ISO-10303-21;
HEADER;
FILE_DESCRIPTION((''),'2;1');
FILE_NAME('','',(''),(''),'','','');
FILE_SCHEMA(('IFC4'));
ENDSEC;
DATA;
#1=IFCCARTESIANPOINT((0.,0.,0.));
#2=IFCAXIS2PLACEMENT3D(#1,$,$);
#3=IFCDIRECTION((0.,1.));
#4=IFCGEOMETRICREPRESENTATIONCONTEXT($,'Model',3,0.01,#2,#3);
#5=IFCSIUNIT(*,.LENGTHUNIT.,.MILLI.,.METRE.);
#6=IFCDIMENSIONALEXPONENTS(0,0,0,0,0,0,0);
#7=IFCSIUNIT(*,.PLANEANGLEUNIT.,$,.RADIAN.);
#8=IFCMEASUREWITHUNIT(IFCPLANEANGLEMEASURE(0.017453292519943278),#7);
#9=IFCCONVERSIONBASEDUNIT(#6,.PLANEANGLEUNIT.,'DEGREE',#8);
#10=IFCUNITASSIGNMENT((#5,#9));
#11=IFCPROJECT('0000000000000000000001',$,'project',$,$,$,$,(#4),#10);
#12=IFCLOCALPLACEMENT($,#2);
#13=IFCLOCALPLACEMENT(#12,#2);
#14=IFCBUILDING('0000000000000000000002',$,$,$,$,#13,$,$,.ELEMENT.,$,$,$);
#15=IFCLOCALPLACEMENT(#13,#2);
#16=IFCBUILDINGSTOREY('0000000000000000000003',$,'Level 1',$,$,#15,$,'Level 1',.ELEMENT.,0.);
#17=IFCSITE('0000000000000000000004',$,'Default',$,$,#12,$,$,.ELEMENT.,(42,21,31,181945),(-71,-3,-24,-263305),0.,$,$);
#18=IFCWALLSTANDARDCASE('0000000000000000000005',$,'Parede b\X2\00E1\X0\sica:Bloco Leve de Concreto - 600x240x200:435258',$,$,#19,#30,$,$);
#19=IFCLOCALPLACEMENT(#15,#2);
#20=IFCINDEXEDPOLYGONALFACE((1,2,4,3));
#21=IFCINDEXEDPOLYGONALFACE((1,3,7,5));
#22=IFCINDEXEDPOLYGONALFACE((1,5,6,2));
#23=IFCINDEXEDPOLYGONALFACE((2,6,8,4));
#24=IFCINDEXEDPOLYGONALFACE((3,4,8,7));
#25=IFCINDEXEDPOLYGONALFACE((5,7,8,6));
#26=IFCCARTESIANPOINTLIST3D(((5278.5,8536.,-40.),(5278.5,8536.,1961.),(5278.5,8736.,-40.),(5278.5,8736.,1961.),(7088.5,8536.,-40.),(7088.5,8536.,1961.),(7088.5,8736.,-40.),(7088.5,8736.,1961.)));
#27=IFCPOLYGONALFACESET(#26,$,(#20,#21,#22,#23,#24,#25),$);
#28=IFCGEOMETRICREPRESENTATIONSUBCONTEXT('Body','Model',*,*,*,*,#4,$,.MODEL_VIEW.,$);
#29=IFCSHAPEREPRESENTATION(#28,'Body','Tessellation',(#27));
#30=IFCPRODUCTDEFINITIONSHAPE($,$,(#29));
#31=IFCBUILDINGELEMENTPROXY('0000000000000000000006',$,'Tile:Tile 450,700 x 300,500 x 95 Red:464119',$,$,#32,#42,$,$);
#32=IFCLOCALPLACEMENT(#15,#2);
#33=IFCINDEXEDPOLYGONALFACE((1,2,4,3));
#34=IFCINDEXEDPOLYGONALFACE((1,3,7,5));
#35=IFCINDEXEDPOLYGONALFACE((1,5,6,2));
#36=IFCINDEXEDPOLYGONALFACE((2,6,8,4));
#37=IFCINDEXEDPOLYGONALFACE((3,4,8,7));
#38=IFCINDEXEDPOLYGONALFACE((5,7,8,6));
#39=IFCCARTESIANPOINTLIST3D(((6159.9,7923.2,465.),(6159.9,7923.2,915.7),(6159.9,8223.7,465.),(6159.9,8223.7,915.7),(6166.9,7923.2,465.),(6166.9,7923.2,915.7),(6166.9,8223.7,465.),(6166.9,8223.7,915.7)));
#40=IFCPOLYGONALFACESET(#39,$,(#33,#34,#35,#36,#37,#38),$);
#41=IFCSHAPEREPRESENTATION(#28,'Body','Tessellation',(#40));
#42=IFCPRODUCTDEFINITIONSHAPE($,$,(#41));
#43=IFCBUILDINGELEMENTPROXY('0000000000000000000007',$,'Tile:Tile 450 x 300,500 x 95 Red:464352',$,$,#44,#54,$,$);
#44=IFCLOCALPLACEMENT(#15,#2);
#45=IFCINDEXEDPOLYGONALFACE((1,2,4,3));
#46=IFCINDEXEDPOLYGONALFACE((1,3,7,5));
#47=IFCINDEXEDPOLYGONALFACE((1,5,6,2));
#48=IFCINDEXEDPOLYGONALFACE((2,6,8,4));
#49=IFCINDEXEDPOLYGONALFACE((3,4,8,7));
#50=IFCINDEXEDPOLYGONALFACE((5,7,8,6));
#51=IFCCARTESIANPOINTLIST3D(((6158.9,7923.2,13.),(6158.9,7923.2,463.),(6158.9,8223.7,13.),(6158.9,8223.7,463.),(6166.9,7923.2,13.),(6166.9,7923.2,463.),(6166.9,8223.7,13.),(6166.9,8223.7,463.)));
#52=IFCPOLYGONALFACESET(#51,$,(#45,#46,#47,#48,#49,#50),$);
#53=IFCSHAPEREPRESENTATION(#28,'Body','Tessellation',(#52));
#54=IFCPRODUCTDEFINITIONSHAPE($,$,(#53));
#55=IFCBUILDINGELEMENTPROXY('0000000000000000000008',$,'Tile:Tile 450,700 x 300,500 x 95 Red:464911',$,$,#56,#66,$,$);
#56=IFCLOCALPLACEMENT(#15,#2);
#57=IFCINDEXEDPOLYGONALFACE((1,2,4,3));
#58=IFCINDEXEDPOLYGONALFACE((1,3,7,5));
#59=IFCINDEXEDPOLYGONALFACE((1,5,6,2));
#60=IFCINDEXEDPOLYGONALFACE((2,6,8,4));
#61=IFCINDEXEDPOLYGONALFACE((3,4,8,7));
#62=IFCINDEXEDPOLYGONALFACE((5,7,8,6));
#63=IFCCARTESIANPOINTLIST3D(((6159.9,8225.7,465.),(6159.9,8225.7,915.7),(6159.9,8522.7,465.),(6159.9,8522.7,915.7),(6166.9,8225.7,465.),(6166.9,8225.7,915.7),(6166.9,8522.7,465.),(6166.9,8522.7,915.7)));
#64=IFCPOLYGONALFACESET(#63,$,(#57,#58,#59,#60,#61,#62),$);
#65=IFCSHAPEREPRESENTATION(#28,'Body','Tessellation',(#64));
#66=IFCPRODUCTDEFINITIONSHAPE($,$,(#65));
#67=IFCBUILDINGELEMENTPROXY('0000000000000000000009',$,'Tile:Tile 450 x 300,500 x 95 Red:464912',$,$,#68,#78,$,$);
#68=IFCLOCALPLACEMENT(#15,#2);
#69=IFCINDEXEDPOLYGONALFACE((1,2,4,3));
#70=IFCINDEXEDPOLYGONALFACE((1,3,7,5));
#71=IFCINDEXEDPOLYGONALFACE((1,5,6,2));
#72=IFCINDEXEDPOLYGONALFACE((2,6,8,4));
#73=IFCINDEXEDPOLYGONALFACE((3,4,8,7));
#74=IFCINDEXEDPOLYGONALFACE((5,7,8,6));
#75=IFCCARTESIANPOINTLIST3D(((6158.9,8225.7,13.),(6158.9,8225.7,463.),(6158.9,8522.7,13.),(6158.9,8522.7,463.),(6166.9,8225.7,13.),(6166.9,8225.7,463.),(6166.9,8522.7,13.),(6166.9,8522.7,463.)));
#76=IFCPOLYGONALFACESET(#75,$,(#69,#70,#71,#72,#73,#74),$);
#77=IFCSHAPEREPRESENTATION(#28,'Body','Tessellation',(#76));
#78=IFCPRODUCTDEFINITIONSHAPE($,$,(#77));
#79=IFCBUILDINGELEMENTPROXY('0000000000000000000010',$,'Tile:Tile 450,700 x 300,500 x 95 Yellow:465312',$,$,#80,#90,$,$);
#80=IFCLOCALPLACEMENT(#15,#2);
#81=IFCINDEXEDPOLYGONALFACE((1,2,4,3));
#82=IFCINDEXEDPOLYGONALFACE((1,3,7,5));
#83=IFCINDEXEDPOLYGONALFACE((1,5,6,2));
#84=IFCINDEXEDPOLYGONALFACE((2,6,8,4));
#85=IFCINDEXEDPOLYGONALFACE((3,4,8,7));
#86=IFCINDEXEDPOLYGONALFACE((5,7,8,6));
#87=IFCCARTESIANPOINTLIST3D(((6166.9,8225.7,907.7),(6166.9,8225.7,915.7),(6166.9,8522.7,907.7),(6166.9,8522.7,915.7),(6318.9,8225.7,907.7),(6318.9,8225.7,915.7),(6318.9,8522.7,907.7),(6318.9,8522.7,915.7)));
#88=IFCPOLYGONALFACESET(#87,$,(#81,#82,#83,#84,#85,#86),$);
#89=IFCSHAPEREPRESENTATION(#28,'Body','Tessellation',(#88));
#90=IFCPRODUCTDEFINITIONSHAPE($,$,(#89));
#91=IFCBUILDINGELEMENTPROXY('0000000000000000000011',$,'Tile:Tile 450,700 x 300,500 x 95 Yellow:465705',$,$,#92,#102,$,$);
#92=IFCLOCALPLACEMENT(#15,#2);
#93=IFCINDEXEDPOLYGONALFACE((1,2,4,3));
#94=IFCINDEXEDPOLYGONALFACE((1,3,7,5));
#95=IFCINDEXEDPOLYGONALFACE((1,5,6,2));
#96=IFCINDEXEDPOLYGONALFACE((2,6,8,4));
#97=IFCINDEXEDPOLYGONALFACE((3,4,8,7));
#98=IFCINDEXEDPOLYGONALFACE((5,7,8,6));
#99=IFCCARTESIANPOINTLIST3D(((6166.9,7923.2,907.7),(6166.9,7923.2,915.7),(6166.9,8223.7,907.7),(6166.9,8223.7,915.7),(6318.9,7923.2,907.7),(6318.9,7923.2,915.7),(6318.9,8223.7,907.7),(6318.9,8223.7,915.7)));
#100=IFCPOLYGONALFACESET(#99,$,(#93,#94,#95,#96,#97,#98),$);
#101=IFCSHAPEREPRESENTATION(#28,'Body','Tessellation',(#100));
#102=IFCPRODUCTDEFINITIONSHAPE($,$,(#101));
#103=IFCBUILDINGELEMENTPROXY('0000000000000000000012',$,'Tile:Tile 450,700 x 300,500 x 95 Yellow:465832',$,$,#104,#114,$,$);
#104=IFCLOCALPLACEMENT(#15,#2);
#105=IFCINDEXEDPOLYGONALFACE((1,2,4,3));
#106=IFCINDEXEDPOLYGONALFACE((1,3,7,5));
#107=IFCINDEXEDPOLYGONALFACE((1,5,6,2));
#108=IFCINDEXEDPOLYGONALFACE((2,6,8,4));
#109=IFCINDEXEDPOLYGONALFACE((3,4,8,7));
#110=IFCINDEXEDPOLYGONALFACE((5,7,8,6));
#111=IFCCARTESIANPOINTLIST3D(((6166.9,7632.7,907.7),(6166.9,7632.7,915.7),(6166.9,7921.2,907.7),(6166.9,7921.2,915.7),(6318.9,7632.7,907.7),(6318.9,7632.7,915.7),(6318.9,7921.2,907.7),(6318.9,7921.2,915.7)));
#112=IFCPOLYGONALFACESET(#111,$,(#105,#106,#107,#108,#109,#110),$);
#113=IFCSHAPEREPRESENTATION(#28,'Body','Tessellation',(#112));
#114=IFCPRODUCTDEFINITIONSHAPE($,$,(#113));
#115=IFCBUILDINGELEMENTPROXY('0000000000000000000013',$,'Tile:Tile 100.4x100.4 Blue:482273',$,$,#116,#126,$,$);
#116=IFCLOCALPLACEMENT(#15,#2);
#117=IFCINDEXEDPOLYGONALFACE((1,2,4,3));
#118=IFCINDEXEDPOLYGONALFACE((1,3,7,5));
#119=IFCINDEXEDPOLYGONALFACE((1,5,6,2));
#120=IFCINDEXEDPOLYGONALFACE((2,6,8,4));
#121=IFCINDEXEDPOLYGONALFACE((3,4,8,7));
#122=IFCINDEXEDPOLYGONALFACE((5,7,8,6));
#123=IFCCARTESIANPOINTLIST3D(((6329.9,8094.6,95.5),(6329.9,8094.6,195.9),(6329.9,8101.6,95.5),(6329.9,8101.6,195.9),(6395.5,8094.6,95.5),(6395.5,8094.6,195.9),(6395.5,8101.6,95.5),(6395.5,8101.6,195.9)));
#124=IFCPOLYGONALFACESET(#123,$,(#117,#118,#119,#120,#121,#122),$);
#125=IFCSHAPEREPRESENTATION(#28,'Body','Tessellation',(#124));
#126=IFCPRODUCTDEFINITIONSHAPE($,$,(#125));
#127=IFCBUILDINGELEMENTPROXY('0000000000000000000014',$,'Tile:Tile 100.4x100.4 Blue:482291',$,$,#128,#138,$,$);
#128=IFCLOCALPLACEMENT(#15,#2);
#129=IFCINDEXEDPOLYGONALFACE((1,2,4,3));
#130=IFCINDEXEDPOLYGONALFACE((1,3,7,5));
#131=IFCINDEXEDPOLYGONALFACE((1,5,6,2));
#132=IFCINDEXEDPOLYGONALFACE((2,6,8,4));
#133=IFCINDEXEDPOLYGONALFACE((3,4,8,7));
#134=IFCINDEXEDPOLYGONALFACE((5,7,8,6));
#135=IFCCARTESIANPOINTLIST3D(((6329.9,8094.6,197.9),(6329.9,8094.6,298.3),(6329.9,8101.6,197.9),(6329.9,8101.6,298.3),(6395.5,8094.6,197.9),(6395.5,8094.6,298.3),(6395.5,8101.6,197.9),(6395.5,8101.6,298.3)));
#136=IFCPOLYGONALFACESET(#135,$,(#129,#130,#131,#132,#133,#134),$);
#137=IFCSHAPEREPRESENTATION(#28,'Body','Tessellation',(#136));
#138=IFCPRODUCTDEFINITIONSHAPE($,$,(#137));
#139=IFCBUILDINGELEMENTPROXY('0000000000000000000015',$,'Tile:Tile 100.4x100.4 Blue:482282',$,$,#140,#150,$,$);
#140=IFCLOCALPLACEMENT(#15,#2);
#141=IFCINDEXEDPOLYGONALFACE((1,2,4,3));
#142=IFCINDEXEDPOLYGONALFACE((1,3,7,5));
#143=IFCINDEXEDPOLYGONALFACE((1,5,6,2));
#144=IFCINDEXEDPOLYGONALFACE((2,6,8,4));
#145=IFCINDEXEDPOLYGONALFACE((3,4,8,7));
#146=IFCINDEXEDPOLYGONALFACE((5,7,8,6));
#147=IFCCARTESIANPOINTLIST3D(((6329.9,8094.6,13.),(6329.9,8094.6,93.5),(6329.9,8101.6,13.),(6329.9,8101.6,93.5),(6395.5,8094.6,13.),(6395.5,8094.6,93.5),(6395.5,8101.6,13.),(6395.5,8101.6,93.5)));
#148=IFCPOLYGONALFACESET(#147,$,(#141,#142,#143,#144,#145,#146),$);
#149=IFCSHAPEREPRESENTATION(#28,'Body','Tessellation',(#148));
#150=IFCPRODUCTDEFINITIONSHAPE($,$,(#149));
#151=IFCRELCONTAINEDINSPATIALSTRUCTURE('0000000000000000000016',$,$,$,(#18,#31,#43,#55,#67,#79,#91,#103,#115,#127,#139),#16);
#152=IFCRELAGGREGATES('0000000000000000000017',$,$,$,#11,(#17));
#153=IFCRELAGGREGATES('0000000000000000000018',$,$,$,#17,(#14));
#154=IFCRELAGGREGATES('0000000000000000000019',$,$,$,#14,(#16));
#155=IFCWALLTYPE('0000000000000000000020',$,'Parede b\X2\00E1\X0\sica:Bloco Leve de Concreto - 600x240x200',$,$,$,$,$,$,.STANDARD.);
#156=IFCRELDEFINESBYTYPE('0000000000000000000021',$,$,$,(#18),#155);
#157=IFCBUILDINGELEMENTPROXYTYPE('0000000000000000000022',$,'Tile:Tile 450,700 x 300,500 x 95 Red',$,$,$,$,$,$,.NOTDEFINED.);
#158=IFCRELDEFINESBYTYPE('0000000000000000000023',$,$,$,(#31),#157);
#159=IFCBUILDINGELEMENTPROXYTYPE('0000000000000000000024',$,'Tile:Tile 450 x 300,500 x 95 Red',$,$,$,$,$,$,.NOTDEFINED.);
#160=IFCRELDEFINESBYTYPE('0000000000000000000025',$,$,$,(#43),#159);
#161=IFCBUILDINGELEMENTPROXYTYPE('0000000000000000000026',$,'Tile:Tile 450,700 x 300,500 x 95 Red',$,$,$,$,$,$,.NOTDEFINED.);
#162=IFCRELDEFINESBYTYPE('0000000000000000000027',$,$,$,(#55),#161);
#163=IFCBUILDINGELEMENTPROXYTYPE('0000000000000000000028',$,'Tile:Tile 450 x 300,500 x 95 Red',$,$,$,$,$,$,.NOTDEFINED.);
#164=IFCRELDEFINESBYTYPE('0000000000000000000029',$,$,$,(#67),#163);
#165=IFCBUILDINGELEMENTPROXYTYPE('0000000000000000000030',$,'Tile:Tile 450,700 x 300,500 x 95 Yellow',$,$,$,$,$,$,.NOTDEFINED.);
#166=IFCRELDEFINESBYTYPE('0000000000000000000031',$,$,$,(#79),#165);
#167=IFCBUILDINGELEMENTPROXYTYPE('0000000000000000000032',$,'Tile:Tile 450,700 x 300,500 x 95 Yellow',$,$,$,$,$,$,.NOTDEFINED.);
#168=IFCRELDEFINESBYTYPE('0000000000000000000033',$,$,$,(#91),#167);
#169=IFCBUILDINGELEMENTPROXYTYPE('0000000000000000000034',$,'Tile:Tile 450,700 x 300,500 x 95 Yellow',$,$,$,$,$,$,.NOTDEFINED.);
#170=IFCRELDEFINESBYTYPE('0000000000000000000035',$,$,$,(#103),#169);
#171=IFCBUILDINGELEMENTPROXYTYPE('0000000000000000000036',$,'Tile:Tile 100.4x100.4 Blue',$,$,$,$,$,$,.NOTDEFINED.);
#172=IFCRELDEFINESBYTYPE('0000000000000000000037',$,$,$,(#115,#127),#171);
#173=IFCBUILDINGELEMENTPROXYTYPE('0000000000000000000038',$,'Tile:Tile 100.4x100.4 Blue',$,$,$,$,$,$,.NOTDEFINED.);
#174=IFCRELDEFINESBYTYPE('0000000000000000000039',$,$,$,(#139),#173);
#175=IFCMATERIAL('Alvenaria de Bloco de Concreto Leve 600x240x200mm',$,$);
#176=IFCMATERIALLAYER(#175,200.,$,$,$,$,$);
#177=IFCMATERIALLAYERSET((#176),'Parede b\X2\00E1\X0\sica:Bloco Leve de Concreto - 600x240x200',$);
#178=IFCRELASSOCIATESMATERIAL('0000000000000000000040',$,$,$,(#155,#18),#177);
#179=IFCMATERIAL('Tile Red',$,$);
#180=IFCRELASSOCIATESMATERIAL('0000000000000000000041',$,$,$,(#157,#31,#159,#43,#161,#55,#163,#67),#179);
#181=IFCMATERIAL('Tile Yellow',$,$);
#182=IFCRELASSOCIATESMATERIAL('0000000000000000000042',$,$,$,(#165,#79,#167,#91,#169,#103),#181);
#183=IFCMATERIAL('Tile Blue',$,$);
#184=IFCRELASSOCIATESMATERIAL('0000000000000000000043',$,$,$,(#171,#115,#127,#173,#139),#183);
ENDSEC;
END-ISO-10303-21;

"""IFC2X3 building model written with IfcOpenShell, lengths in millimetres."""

from ifc_helpers import new_model, entity, si_unit, converted_unit, direction, frame, frame_2d, origin, origin_2d_with_axis, place, context, subcontext, project, spatial, rectangle, extrude, source, transform, mapped, material, layer, layer_set, layer_usage, type_object, type_shapes, element, save


model = new_model("IFC2X3")

# Units and contexts
model_context = context("Model", 3, precision=0.01, world=origin(), true_north=direction((0.0, 1.0)))
body_context = subcontext(model_context, "Body", "Model", "MODEL_VIEW")
ifc_project = project(units=[si_unit("LENGTHUNIT", "METRE", prefix="MILLI"), converted_unit("PLANEANGLEUNIT", "DEGREE", entity("IfcPlaneAngleMeasure", 0.017453292519943278), si_unit("PLANEANGLEUNIT", "RADIAN"), dimensions=[0, 0, 0, 0, 0, 0, 0])], contexts=[model_context])

# Site, building, storey
site_placement = place(None, origin())
site = spatial("IfcSite", under=ifc_project, at=site_placement, Name="Default", CompositionType="ELEMENT", RefLatitude=(42, 21, 31, 181945), RefLongitude=(-71, -3, -24, -263305), RefElevation=0.0)
building_placement = place(site_placement, origin())
building = spatial("IfcBuilding", under=site, at=building_placement, CompositionType="ELEMENT")
storey_placement = place(building_placement, origin())
storey = spatial("IfcBuildingStorey", under=building, at=storey_placement, Name="Level 1", LongName="Level 1", CompositionType="ELEMENT", Elevation=0.0)

# Wall
ifc_material_1 = material(Name="Alvenaria de Bloco de Concreto Leve 600x240x200mm")
ifc_layer = layer(ifc_material_1, 200.0)
ifc_layer_set = layer_set([ifc_layer], Name="Parede básica:Bloco Leve de Concreto - 600x240x200")
ifc_layer_usage = layer_usage(ifc_layer_set, "AXIS2", "NEGATIVE", 100.0)
wall_type = type_object("IfcWallType", Name="Parede básica:Bloco Leve de Concreto - 600x240x200", PredefinedType="STANDARD", material=ifc_layer_set)
wall_placement = place(storey_placement, frame((5278.5, 8636.0, -40.0)))
element("IfcWallStandardCase", 1, at=wall_placement, inside=storey, type_object=wall_type, material=ifc_layer_usage, Name="Parede básica:Bloco Leve de Concreto - 600x240x200:435258", context=body_context, shape_type="SweptSolid", body=[
    extrude(rectangle(XDim=1810.0, YDim=200.0, at=frame_2d((905.0, 0.0), x_axis=(-1.0, 0.0))), origin(), (0.0, 0.0, 1.0), 2001.0),
])

# Building element proxies
ifc_material_2 = material(Name="Tile Red")
building_element_proxy_type_1 = type_object("IfcBuildingElementProxyType", Name="Tile:Tile 450,700 x 300,500 x 95 Red", PredefinedType="NOTDEFINED", material=ifc_material_2)
shared_shape_1 = source(origin(), body_context, "Body", "SweptSolid", [
    extrude(rectangle(XDim=300.5, YDim=450.7, at=frame_2d((0.0, 0.0), x_axis=(1.0, 0.0))), frame((-150.2, 225.4, 0.0)), (0.0, 0.0, 1.0), 7.0),
])
type_shapes(building_element_proxy_type_1, [shared_shape_1])
proxy_1_placement = place(storey_placement, frame((6166.9, 7923.2, 465.0), z_axis=(-1.0, 0.0, 0.0), x_axis=(0.0, -1.0, 0.0)))
element("IfcBuildingElementProxy", 2, at=proxy_1_placement, inside=storey, type_object=building_element_proxy_type_1, material=ifc_material_2, Name="Tile:Tile 450,700 x 300,500 x 95 Red:464119", context=body_context, shape_type="MappedRepresentation", body=[
    mapped(shared_shape_1, transform((0.0, 0.0, 0.0), scale=1.0)),
])
building_element_proxy_type_2 = type_object("IfcBuildingElementProxyType", Name="Tile:Tile 450 x 300,500 x 95 Red", PredefinedType="NOTDEFINED", material=ifc_material_2)
shared_shape_2 = source(origin(), body_context, "Body", "SweptSolid", [
    extrude(rectangle(XDim=300.5, YDim=450.0, at=frame_2d((0.0, 0.0), x_axis=(1.0, 0.0))), frame((-150.2, 225.0, 0.0)), (0.0, 0.0, 1.0), 8.0),
])
type_shapes(building_element_proxy_type_2, [shared_shape_2])
proxy_2_placement = place(storey_placement, frame((6166.9, 7923.2, 13.0), z_axis=(-1.0, 0.0, 0.0), x_axis=(0.0, -1.0, 0.0)))
element("IfcBuildingElementProxy", 3, at=proxy_2_placement, inside=storey, type_object=building_element_proxy_type_2, material=ifc_material_2, Name="Tile:Tile 450 x 300,500 x 95 Red:464352", context=body_context, shape_type="MappedRepresentation", body=[
    mapped(shared_shape_2, transform((0.0, 0.0, 0.0), scale=1.0)),
])
building_element_proxy_type_3 = type_object("IfcBuildingElementProxyType", Name="Tile:Tile 450,700 x 300,500 x 95 Red", PredefinedType="NOTDEFINED", material=ifc_material_2)
shared_shape_3 = source(origin(), body_context, "Body", "SweptSolid", [
    extrude(rectangle(XDim=450.7, YDim=297.0, at=origin_2d_with_axis()), frame((-148.5, 225.4, 0.0), z_axis=(0.0, 0.0, 1.0), x_axis=(0.0, 1.0, 0.0)), (0.0, 0.0, 1.0), 7.0),
])
type_shapes(building_element_proxy_type_3, [shared_shape_3])
proxy_3_placement = place(storey_placement, frame((6166.9, 8225.7, 465.0), z_axis=(-1.0, 0.0, 0.0), x_axis=(0.0, -1.0, 0.0)))
element("IfcBuildingElementProxy", 4, at=proxy_3_placement, inside=storey, type_object=building_element_proxy_type_3, material=ifc_material_2, Name="Tile:Tile 450,700 x 300,500 x 95 Red:464911", context=body_context, shape_type="MappedRepresentation", body=[
    mapped(shared_shape_3, transform((0.0, 0.0, 0.0), scale=1.0)),
])
building_element_proxy_type_4 = type_object("IfcBuildingElementProxyType", Name="Tile:Tile 450 x 300,500 x 95 Red", PredefinedType="NOTDEFINED", material=ifc_material_2)
shared_shape_4 = source(origin(), body_context, "Body", "SweptSolid", [
    extrude(rectangle(XDim=450.0, YDim=297.0, at=origin_2d_with_axis()), frame((-148.5, 225.0, 0.0), z_axis=(0.0, 0.0, 1.0), x_axis=(0.0, 1.0, 0.0)), (0.0, 0.0, 1.0), 8.0),
])
type_shapes(building_element_proxy_type_4, [shared_shape_4])
proxy_4_placement = place(storey_placement, frame((6166.9, 8225.7, 13.0), z_axis=(-1.0, 0.0, 0.0), x_axis=(0.0, -1.0, 0.0)))
element("IfcBuildingElementProxy", 5, at=proxy_4_placement, inside=storey, type_object=building_element_proxy_type_4, material=ifc_material_2, Name="Tile:Tile 450 x 300,500 x 95 Red:464912", context=body_context, shape_type="MappedRepresentation", body=[
    mapped(shared_shape_4, transform((0.0, 0.0, 0.0), scale=1.0)),
])
ifc_material_3 = material(Name="Tile Yellow")
building_element_proxy_type_5 = type_object("IfcBuildingElementProxyType", Name="Tile:Tile 450,700 x 300,500 x 95 Yellow", PredefinedType="NOTDEFINED", material=ifc_material_3)
shared_shape_5 = source(origin(), body_context, "Body", "SweptSolid", [
    extrude(rectangle(XDim=152.0, YDim=297.0, at=origin_2d_with_axis()), frame((-76.0, -148.5, 0.0), z_axis=(0.0, 0.0, 1.0), x_axis=(-1.0, 0.0, 0.0)), (0.0, 0.0, 1.0), 8.0),
])
type_shapes(building_element_proxy_type_5, [shared_shape_5])
proxy_5_placement = place(storey_placement, frame((6318.9, 8522.7, 907.7)))
element("IfcBuildingElementProxy", 6, at=proxy_5_placement, inside=storey, type_object=building_element_proxy_type_5, material=ifc_material_3, Name="Tile:Tile 450,700 x 300,500 x 95 Yellow:465312", context=body_context, shape_type="MappedRepresentation", body=[
    mapped(shared_shape_5, transform((0.0, 0.0, 0.0), scale=1.0)),
])
building_element_proxy_type_6 = type_object("IfcBuildingElementProxyType", Name="Tile:Tile 450,700 x 300,500 x 95 Yellow", PredefinedType="NOTDEFINED", material=ifc_material_3)
shared_shape_6 = source(origin(), body_context, "Body", "SweptSolid", [
    extrude(rectangle(XDim=152.0, YDim=300.5, at=origin_2d_with_axis()), frame((-76.0, -150.3, 0.0), z_axis=(0.0, 0.0, 1.0), x_axis=(-1.0, 0.0, 0.0)), (0.0, 0.0, 1.0), 8.0),
])
type_shapes(building_element_proxy_type_6, [shared_shape_6])
proxy_6_placement = place(storey_placement, frame((6318.9, 8223.7, 907.7)))
element("IfcBuildingElementProxy", 7, at=proxy_6_placement, inside=storey, type_object=building_element_proxy_type_6, material=ifc_material_3, Name="Tile:Tile 450,700 x 300,500 x 95 Yellow:465705", context=body_context, shape_type="MappedRepresentation", body=[
    mapped(shared_shape_6, transform((0.0, 0.0, 0.0), scale=1.0)),
])
building_element_proxy_type_7 = type_object("IfcBuildingElementProxyType", Name="Tile:Tile 450,700 x 300,500 x 95 Yellow", PredefinedType="NOTDEFINED", material=ifc_material_3)
shared_shape_7 = source(origin(), body_context, "Body", "SweptSolid", [
    extrude(rectangle(XDim=152.0, YDim=288.5, at=origin_2d_with_axis()), frame((-76.0, -144.3, 0.0), z_axis=(0.0, 0.0, 1.0), x_axis=(-1.0, 0.0, 0.0)), (0.0, 0.0, 1.0), 8.0),
])
type_shapes(building_element_proxy_type_7, [shared_shape_7])
proxy_7_placement = place(storey_placement, frame((6318.9, 7921.2, 907.7)))
element("IfcBuildingElementProxy", 8, at=proxy_7_placement, inside=storey, type_object=building_element_proxy_type_7, material=ifc_material_3, Name="Tile:Tile 450,700 x 300,500 x 95 Yellow:465832", context=body_context, shape_type="MappedRepresentation", body=[
    mapped(shared_shape_7, transform((0.0, 0.0, 0.0), scale=1.0)),
])
ifc_material_4 = material(Name="Tile Blue")
building_element_proxy_type_8 = type_object("IfcBuildingElementProxyType", Name="Tile:Tile 100.4x100.4 Blue", PredefinedType="NOTDEFINED", material=ifc_material_4)
shared_shape_8 = source(origin(), body_context, "Body", "SweptSolid", [
    extrude(rectangle(XDim=65.6, YDim=100.4, at=frame_2d((0.0, 0.0), x_axis=(1.0, 0.0))), frame((-32.8, -50.2, 0.0), z_axis=(0.0, 0.0, 1.0), x_axis=(-1.0, 0.0, 0.0)), (0.0, 0.0, 1.0), 7.0),
])
type_shapes(building_element_proxy_type_8, [shared_shape_8])
for number, where, z_axis, x_axis, name in (
    (9, (6329.9, 8101.6, 95.5), (0.0, -1.0, 0.0), (-1.0, 0.0, 0.0), "Tile:Tile 100.4x100.4 Blue:482273"),
    (10, (6329.9, 8101.6, 197.9), (0.0, -1.0, 0.0), (-1.0, 0.0, 0.0), "Tile:Tile 100.4x100.4 Blue:482291"),
):
    element("IfcBuildingElementProxy", number, at=place(storey_placement, frame(where, z_axis=z_axis, x_axis=x_axis)), inside=storey, type_object=building_element_proxy_type_8, material=ifc_material_4, Name=name, context=body_context, shape_type="MappedRepresentation", body=[
        mapped(shared_shape_8, transform((0.0, 0.0, 0.0), scale=1.0)),
    ])
building_element_proxy_type_9 = type_object("IfcBuildingElementProxyType", Name="Tile:Tile 100.4x100.4 Blue", PredefinedType="NOTDEFINED", material=ifc_material_4)
shared_shape_9 = source(origin(), body_context, "Body", "SweptSolid", [
    extrude(rectangle(XDim=65.6, YDim=80.5, at=frame_2d((0.0, 0.0), x_axis=(1.0, 0.0))), frame((-32.8, -40.3, 0.0), z_axis=(0.0, 0.0, 1.0), x_axis=(-1.0, 0.0, 0.0)), (0.0, 0.0, 1.0), 7.0),
])
type_shapes(building_element_proxy_type_9, [shared_shape_9])
proxy_8_placement = place(storey_placement, frame((6329.9, 8101.6, 13.0), z_axis=(0.0, -1.0, 0.0), x_axis=(-1.0, 0.0, 0.0)))
element("IfcBuildingElementProxy", 11, at=proxy_8_placement, inside=storey, type_object=building_element_proxy_type_9, material=ifc_material_4, Name="Tile:Tile 100.4x100.4 Blue:482282", context=body_context, shape_type="MappedRepresentation", body=[
    mapped(shared_shape_9, transform((0.0, 0.0, 0.0), scale=1.0)),
])

save(model, "model.ifc")
